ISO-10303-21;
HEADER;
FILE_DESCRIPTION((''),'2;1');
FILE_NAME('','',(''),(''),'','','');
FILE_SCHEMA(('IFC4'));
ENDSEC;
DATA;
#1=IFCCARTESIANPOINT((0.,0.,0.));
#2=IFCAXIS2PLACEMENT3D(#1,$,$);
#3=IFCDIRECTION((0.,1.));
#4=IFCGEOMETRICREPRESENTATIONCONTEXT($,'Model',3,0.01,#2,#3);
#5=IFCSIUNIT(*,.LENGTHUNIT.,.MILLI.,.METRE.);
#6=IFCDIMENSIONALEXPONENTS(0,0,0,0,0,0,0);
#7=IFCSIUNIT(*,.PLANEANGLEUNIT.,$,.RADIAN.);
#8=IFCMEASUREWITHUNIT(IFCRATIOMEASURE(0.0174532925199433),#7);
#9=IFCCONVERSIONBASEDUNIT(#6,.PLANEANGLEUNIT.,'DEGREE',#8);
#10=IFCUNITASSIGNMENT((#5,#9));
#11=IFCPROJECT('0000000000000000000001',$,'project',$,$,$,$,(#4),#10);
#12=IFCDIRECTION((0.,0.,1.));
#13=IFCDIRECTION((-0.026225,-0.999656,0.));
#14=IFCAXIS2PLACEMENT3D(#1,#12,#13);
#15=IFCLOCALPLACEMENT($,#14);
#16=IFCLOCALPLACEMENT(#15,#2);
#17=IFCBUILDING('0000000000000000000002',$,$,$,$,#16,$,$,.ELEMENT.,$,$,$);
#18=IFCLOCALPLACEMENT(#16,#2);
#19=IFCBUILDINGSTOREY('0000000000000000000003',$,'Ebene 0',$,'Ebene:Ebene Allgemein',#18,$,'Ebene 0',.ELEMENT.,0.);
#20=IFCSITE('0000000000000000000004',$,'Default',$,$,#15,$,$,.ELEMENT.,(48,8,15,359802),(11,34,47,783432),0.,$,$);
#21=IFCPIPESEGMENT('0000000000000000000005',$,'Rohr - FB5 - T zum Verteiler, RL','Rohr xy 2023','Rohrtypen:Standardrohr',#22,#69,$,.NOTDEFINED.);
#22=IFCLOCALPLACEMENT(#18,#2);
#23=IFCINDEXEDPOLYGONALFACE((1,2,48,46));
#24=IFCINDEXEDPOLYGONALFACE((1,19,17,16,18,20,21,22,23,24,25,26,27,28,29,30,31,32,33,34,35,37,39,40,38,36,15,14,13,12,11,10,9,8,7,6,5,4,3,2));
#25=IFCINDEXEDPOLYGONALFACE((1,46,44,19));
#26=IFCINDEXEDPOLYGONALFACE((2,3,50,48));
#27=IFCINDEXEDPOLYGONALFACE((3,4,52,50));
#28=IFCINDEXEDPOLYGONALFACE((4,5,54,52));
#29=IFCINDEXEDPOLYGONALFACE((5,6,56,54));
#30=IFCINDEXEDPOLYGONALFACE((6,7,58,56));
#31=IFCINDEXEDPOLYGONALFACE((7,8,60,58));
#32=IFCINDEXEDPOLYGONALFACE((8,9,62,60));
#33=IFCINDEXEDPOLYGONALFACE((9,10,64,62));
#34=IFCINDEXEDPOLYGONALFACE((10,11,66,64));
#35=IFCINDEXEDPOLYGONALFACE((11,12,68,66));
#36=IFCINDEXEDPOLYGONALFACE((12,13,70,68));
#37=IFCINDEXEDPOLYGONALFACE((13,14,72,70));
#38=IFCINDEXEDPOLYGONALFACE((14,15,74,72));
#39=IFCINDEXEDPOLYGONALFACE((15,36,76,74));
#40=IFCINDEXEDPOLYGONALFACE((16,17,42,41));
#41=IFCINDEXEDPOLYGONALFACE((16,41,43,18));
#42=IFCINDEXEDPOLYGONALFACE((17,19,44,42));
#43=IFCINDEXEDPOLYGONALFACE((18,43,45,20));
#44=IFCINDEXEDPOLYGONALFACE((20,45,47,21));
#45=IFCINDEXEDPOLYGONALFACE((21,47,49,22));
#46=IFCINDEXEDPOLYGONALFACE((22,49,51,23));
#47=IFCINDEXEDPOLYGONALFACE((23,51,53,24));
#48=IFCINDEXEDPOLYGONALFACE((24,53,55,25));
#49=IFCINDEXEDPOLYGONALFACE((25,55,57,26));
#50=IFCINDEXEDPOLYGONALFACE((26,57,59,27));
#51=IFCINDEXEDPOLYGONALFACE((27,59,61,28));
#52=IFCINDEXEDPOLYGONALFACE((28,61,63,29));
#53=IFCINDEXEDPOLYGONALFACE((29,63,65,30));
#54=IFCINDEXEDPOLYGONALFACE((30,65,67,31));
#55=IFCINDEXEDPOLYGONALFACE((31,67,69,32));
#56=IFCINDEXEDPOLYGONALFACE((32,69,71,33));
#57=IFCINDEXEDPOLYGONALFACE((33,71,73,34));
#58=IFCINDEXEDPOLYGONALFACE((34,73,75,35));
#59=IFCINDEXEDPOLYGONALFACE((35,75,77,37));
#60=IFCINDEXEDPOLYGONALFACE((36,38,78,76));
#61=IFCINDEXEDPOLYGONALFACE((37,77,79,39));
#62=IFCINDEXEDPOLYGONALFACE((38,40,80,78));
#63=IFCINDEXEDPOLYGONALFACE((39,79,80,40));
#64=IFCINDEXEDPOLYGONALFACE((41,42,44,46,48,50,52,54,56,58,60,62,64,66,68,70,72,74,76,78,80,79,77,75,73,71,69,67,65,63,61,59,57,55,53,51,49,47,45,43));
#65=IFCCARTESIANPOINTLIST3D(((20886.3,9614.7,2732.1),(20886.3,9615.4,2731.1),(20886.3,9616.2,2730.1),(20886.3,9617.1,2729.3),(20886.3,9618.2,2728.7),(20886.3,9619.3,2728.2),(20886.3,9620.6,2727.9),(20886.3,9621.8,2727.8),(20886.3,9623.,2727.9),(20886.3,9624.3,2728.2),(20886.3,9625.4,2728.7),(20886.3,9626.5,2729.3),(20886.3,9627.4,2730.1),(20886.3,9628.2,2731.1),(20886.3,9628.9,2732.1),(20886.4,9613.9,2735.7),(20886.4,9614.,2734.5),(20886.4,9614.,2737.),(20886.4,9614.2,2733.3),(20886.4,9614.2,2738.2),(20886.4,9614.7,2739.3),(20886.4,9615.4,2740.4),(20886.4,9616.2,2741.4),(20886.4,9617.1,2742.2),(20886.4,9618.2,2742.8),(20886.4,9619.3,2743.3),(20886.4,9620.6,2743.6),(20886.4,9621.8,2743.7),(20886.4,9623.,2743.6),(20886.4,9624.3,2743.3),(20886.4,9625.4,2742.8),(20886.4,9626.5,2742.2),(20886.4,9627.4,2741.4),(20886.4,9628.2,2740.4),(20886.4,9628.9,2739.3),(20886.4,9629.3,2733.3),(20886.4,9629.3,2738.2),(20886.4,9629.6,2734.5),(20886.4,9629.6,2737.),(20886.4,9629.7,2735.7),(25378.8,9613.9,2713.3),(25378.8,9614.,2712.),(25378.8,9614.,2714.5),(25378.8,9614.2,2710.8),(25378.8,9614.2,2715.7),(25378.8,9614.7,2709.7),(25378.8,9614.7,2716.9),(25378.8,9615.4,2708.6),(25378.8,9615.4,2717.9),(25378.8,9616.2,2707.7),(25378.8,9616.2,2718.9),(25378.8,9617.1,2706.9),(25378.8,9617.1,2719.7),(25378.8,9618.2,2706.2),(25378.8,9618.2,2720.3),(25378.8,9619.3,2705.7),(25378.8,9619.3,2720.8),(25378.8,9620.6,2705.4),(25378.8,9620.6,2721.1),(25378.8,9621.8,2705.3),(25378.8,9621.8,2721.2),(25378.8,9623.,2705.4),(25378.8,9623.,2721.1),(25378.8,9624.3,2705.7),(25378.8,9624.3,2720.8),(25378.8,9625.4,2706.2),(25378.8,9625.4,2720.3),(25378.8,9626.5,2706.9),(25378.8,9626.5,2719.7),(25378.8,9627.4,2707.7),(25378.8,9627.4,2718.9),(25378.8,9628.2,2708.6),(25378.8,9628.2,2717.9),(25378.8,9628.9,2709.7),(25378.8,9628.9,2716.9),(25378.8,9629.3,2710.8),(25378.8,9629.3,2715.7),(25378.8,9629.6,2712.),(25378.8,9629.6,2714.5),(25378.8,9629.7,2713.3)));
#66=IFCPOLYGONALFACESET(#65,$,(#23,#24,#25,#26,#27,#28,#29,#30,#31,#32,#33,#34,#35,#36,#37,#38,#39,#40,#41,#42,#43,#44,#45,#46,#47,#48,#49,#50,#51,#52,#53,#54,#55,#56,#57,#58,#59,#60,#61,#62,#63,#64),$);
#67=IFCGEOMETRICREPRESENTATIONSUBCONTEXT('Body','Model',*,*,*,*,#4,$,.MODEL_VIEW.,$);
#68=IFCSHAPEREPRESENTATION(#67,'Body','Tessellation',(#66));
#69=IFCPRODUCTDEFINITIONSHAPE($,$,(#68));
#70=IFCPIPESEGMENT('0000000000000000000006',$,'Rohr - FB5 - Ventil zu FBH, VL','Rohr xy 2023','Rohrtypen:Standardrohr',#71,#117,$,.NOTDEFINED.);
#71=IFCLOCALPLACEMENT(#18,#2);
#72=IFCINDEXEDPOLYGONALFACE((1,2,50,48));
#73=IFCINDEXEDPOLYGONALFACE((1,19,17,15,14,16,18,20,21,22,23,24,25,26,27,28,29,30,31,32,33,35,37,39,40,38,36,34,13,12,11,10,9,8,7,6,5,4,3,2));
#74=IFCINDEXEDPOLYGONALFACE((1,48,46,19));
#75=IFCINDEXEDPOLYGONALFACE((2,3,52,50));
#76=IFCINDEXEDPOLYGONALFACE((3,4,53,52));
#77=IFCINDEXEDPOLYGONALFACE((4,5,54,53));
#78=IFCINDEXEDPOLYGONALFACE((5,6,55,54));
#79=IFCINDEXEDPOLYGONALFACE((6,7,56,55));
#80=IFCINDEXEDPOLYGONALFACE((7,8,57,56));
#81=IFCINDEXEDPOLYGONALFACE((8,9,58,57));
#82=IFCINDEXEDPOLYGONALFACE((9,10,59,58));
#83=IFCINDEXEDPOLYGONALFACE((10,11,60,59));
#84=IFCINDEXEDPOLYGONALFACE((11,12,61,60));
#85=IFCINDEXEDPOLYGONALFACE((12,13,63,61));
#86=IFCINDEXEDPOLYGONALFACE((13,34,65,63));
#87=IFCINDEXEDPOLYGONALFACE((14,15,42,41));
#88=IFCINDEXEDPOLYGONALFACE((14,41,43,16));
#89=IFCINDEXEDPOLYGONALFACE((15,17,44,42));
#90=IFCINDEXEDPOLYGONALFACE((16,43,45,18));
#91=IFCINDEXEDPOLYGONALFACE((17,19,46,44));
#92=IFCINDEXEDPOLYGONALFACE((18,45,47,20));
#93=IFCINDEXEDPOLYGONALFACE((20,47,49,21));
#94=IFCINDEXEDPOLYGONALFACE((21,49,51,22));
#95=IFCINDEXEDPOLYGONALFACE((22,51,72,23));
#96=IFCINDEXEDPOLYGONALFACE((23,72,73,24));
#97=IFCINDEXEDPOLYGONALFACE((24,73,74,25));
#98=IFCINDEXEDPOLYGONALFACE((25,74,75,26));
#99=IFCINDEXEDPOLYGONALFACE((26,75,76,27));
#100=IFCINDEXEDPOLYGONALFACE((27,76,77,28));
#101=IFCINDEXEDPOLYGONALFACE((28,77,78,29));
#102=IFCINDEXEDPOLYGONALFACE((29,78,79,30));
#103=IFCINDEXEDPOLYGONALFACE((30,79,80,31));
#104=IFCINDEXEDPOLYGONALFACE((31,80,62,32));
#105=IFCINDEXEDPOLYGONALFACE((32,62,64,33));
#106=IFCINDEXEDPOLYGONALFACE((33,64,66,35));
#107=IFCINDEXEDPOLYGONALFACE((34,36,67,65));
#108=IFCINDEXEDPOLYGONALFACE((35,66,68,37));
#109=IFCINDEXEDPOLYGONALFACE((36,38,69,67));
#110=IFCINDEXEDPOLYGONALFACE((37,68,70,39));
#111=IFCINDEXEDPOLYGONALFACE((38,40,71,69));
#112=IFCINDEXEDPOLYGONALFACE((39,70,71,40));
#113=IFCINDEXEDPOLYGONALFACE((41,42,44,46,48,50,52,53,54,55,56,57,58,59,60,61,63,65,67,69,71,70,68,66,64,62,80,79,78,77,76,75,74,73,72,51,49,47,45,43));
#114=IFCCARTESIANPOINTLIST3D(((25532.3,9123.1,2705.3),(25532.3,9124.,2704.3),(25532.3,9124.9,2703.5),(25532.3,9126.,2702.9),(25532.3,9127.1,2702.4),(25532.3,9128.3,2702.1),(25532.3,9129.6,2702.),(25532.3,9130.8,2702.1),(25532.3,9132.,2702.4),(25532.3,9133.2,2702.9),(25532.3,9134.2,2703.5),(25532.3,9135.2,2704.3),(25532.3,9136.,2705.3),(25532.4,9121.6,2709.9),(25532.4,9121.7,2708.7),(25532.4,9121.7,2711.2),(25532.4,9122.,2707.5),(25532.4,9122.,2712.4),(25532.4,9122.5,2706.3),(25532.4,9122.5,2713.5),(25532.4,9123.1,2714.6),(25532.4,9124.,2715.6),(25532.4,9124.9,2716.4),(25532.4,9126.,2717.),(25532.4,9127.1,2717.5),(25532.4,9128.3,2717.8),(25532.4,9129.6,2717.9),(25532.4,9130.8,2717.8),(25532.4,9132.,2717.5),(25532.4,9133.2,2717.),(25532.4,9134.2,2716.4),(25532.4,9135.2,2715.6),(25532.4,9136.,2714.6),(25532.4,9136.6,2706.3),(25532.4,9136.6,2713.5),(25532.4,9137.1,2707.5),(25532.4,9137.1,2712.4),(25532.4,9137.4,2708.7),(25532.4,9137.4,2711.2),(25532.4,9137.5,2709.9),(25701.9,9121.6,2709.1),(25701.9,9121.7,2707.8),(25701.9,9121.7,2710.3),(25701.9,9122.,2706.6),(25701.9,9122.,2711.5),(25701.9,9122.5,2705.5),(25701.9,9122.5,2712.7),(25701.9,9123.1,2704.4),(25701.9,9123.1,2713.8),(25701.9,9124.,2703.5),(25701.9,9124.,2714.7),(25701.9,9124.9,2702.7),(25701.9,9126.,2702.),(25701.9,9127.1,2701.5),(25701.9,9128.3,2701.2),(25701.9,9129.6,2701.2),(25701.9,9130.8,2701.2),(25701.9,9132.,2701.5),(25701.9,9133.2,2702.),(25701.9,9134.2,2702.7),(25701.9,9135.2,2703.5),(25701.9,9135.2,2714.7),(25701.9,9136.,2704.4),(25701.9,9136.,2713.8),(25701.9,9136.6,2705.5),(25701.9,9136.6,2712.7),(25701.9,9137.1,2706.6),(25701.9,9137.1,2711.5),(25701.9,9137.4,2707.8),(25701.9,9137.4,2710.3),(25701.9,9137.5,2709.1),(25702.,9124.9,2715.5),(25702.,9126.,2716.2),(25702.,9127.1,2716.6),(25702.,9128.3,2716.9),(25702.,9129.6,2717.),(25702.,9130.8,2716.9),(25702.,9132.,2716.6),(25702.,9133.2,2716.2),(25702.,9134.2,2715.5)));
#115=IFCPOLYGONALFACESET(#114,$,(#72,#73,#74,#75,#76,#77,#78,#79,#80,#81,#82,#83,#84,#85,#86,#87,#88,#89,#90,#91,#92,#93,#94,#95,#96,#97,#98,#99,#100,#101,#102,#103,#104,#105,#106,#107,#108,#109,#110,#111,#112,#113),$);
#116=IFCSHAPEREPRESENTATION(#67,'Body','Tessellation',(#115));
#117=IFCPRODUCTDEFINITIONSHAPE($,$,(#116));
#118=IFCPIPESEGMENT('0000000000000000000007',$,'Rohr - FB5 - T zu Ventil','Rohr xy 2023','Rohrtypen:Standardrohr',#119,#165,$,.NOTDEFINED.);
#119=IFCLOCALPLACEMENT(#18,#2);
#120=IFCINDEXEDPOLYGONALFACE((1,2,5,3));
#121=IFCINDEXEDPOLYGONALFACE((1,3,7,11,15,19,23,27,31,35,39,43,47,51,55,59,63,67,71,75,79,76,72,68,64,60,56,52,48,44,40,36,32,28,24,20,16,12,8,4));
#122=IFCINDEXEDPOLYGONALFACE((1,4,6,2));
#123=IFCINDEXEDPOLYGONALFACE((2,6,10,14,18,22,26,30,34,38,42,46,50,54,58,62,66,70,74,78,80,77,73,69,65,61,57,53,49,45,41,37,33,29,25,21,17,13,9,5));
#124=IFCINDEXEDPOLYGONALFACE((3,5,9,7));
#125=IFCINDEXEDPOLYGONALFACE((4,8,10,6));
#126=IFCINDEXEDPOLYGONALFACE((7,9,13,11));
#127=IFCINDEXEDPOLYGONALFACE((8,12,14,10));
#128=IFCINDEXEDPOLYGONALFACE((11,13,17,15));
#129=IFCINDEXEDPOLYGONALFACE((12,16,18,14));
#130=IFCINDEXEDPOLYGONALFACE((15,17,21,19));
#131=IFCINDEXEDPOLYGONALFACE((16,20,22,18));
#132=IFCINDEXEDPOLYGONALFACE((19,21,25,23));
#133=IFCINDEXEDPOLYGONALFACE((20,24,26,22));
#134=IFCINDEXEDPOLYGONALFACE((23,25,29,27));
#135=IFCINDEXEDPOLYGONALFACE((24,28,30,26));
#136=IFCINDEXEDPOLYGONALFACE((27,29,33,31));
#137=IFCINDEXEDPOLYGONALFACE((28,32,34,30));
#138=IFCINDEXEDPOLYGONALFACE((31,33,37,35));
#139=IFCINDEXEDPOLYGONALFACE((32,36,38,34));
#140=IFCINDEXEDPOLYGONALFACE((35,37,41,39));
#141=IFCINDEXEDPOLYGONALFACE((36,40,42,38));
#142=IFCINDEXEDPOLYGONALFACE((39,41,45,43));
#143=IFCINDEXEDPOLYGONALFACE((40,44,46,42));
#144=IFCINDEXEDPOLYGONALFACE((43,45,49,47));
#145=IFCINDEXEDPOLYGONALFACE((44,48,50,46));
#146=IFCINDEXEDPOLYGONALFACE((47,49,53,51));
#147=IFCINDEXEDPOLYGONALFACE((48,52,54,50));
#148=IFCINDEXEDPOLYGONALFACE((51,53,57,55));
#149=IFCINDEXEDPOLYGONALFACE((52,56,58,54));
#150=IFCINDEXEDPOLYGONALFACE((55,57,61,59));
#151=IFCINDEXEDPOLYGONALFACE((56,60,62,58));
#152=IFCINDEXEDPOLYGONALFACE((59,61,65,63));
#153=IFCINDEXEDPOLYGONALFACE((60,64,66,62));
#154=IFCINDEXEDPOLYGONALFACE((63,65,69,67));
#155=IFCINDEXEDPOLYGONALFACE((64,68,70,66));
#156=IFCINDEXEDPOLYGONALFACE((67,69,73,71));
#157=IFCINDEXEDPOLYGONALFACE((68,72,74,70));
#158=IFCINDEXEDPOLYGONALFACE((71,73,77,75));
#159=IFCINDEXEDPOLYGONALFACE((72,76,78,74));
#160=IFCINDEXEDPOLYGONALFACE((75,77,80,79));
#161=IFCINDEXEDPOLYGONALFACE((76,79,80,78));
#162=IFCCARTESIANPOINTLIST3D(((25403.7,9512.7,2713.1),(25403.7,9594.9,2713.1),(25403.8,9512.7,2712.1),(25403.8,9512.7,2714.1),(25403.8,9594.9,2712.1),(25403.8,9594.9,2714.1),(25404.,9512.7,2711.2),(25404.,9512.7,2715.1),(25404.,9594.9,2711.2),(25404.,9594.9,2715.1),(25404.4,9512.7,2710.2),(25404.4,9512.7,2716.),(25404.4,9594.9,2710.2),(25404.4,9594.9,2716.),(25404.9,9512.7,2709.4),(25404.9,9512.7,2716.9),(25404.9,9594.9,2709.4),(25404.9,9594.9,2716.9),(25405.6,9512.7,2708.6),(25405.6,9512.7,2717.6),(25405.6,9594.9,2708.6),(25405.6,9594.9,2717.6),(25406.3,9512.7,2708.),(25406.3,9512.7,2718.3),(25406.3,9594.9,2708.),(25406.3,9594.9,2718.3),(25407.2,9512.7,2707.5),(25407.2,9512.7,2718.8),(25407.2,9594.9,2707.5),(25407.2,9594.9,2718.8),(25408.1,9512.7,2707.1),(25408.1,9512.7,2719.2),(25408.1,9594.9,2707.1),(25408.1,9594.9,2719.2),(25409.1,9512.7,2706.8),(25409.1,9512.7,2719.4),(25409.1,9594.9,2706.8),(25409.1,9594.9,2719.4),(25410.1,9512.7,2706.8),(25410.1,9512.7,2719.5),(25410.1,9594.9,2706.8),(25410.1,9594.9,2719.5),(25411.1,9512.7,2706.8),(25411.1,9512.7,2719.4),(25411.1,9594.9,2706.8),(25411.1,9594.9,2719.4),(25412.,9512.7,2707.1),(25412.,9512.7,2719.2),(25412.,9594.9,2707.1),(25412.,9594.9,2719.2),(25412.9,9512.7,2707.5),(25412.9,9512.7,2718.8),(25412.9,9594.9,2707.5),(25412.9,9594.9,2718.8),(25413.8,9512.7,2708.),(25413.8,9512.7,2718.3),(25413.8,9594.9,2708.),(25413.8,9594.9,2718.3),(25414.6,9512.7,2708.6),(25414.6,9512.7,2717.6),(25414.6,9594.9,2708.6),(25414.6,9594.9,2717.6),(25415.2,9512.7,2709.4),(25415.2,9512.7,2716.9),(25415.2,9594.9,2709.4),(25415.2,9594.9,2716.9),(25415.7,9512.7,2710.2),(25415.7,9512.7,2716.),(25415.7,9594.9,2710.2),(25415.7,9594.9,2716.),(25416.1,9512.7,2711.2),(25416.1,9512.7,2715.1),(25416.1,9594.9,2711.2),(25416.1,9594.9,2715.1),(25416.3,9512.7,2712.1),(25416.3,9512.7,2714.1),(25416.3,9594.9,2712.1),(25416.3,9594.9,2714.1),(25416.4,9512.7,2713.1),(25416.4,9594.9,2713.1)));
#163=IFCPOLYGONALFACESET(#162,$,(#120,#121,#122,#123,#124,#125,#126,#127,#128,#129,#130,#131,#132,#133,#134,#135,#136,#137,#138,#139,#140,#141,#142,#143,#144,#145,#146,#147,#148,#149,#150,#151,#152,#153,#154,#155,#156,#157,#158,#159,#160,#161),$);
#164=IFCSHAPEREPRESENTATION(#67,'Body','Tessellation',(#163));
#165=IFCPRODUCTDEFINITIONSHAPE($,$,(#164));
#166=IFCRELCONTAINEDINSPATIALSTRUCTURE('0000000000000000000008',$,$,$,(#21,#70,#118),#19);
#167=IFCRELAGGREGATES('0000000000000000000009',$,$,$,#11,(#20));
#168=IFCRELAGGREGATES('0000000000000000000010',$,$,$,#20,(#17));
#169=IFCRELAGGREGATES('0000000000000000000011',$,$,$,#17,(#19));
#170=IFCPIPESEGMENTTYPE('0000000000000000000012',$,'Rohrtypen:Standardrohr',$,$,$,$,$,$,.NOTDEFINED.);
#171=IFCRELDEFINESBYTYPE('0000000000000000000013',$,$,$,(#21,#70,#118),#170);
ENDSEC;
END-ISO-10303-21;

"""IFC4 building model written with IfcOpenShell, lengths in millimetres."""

from ifc_helpers import new_model, entity, si_unit, converted_unit, direction, frame, origin, place, context, subcontext, project, spatial, indexed_curve, outline, extrude, type_object, element, save


model = new_model("IFC4")

# Units and contexts
model_context = context("Model", 3, precision=0.01, world=origin(), true_north=direction((0.0, 1.0)))
body_context = subcontext(model_context, "Body", "Model", "MODEL_VIEW")
ifc_project = project(units=[si_unit("LENGTHUNIT", "METRE", prefix="MILLI"), converted_unit("PLANEANGLEUNIT", "DEGREE", entity("IfcRatioMeasure", 0.0174532925199433), si_unit("PLANEANGLEUNIT", "RADIAN"), dimensions=[0, 0, 0, 0, 0, 0, 0])], contexts=[model_context])

# Site, building, storey
site_placement = place(None, frame((0.0, 0.0, 0.0), z_axis=(0.0, 0.0, 1.0), x_axis=(-0.026225, -0.999656, 0.0)))
site = spatial("IfcSite", under=ifc_project, at=site_placement, Name="Default", CompositionType="ELEMENT", RefLatitude=(48, 8, 15, 359802), RefLongitude=(11, 34, 47, 783432), RefElevation=0.0)
building_placement = place(site_placement, origin())
building = spatial("IfcBuilding", under=site, at=building_placement, CompositionType="ELEMENT")
storey_placement = place(building_placement, origin())
storey = spatial("IfcBuildingStorey", under=building, at=storey_placement, Name="Ebene 0", ObjectType="Ebene:Ebene Allgemein", LongName="Ebene 0", CompositionType="ELEMENT", Elevation=0.0)

# Pipe segments
pipe_segment_type = type_object("IfcPipeSegmentType", Name="Rohrtypen:Standardrohr", PredefinedType="NOTDEFINED")
pipe_segment_1_placement = place(storey_placement, origin())
element("IfcPipeSegment", 1, at=pipe_segment_1_placement, inside=storey, type_object=pipe_segment_type, Name="Rohr - FB5 - T zum Verteiler, RL", Description="Rohr xy 2023", ObjectType="Rohrtypen:Standardrohr", PredefinedType="NOTDEFINED", context=body_context, shape_type="SweptSolid", body=[
    extrude(outline(indexed_curve([(7.9, 0.0), (7.8, 1.2), (7.6, 2.5), (7.1, 3.6), (6.4, 4.7), (5.6, 5.6), (4.7, 6.4), (3.6, 7.1), (2.5, 7.6), (1.2, 7.8), (0.0, 7.9), (-1.2, 7.8), (-2.5, 7.6), (-3.6, 7.1), (-4.7, 6.4), (-5.6, 5.6), (-6.4, 4.7), (-7.1, 3.6), (-7.6, 2.5), (-7.8, 1.2), (-7.9, 0.0), (-7.8, -1.2), (-7.6, -2.5), (-7.1, -3.6), (-6.4, -4.7), (-5.6, -5.6), (-4.7, -6.4), (-3.6, -7.1), (-2.5, -7.6), (-1.2, -7.8), (0.0, -7.9), (1.2, -7.8), (2.5, -7.6), (3.6, -7.1), (4.7, -6.4), (5.6, -5.6), (6.4, -4.7), (7.1, -3.6), (7.6, -2.5), (7.8, -1.2), (7.9, 0.0)], self_intersect=False)), frame((25378.8, 9621.8, 2713.3), z_axis=(-0.999988, 0.0, 0.005), x_axis=(0.0, 1.0, 0.0)), (0.0, 0.0, 1.0), 4492.5),
])
pipe_segment_2_placement = place(storey_placement, origin())
element("IfcPipeSegment", 2, at=pipe_segment_2_placement, inside=storey, type_object=pipe_segment_type, Name="Rohr - FB5 - Ventil zu FBH, VL", Description="Rohr xy 2023", ObjectType="Rohrtypen:Standardrohr", PredefinedType="NOTDEFINED", context=body_context, shape_type="SweptSolid", body=[
    extrude(outline(indexed_curve([(7.9, 0.0), (7.8, 1.2), (7.6, 2.5), (7.1, 3.6), (6.4, 4.7), (5.6, 5.6), (4.7, 6.4), (3.6, 7.1), (2.5, 7.6), (1.2, 7.8), (0.0, 7.9), (-1.2, 7.8), (-2.5, 7.6), (-3.6, 7.1), (-4.7, 6.4), (-5.6, 5.6), (-6.4, 4.7), (-7.1, 3.6), (-7.6, 2.5), (-7.8, 1.2), (-7.9, 0.0), (-7.8, -1.2), (-7.6, -2.5), (-7.1, -3.6), (-6.4, -4.7), (-5.6, -5.6), (-4.7, -6.4), (-3.6, -7.1), (-2.5, -7.6), (-1.2, -7.8), (0.0, -7.9), (1.2, -7.8), (2.5, -7.6), (3.6, -7.1), (4.7, -6.4), (5.6, -5.6), (6.4, -4.7), (7.1, -3.6), (7.6, -2.5), (7.8, -1.2), (7.9, 0.0)], self_intersect=False)), frame((25532.4, 9129.6, 2709.9), z_axis=(0.999988, 0.0, -0.005), x_axis=(0.0, 1.0, 0.0)), (0.0, 0.0, 1.0), 169.5),
])
pipe_segment_3_placement = place(storey_placement, origin())
element("IfcPipeSegment", 3, at=pipe_segment_3_placement, inside=storey, type_object=pipe_segment_type, Name="Rohr - FB5 - T zu Ventil", Description="Rohr xy 2023", ObjectType="Rohrtypen:Standardrohr", PredefinedType="NOTDEFINED", context=body_context, shape_type="SweptSolid", body=[
    extrude(outline(indexed_curve([(6.3, 0.0), (6.3, 1.0), (6.0, 2.0), (5.7, 2.9), (5.1, 3.7), (4.5, 4.5), (3.7, 5.1), (2.9, 5.7), (2.0, 6.0), (1.0, 6.3), (0.0, 6.4), (-1.0, 6.3), (-2.0, 6.0), (-2.9, 5.7), (-3.7, 5.1), (-4.5, 4.5), (-5.1, 3.7), (-5.7, 2.9), (-6.0, 2.0), (-6.3, 1.0), (-6.3, 0.0), (-6.3, -1.0), (-6.0, -2.0), (-5.7, -2.9), (-5.1, -3.7), (-4.5, -4.5), (-3.7, -5.1), (-2.9, -5.7), (-2.0, -6.0), (-1.0, -6.3), (0.0, -6.4), (1.0, -6.3), (2.0, -6.0), (2.9, -5.7), (3.7, -5.1), (4.5, -4.5), (5.1, -3.7), (5.7, -2.9), (6.0, -2.0), (6.3, -1.0), (6.3, 0.0)], self_intersect=False)), frame((25410.1, 9512.7, 2713.1), z_axis=(0.0, 1.0, 0.0), x_axis=(-1.0, 0.0, 0.0)), (0.0, 0.0, 1.0), 82.2),
])

save(model, "model.ifc")
